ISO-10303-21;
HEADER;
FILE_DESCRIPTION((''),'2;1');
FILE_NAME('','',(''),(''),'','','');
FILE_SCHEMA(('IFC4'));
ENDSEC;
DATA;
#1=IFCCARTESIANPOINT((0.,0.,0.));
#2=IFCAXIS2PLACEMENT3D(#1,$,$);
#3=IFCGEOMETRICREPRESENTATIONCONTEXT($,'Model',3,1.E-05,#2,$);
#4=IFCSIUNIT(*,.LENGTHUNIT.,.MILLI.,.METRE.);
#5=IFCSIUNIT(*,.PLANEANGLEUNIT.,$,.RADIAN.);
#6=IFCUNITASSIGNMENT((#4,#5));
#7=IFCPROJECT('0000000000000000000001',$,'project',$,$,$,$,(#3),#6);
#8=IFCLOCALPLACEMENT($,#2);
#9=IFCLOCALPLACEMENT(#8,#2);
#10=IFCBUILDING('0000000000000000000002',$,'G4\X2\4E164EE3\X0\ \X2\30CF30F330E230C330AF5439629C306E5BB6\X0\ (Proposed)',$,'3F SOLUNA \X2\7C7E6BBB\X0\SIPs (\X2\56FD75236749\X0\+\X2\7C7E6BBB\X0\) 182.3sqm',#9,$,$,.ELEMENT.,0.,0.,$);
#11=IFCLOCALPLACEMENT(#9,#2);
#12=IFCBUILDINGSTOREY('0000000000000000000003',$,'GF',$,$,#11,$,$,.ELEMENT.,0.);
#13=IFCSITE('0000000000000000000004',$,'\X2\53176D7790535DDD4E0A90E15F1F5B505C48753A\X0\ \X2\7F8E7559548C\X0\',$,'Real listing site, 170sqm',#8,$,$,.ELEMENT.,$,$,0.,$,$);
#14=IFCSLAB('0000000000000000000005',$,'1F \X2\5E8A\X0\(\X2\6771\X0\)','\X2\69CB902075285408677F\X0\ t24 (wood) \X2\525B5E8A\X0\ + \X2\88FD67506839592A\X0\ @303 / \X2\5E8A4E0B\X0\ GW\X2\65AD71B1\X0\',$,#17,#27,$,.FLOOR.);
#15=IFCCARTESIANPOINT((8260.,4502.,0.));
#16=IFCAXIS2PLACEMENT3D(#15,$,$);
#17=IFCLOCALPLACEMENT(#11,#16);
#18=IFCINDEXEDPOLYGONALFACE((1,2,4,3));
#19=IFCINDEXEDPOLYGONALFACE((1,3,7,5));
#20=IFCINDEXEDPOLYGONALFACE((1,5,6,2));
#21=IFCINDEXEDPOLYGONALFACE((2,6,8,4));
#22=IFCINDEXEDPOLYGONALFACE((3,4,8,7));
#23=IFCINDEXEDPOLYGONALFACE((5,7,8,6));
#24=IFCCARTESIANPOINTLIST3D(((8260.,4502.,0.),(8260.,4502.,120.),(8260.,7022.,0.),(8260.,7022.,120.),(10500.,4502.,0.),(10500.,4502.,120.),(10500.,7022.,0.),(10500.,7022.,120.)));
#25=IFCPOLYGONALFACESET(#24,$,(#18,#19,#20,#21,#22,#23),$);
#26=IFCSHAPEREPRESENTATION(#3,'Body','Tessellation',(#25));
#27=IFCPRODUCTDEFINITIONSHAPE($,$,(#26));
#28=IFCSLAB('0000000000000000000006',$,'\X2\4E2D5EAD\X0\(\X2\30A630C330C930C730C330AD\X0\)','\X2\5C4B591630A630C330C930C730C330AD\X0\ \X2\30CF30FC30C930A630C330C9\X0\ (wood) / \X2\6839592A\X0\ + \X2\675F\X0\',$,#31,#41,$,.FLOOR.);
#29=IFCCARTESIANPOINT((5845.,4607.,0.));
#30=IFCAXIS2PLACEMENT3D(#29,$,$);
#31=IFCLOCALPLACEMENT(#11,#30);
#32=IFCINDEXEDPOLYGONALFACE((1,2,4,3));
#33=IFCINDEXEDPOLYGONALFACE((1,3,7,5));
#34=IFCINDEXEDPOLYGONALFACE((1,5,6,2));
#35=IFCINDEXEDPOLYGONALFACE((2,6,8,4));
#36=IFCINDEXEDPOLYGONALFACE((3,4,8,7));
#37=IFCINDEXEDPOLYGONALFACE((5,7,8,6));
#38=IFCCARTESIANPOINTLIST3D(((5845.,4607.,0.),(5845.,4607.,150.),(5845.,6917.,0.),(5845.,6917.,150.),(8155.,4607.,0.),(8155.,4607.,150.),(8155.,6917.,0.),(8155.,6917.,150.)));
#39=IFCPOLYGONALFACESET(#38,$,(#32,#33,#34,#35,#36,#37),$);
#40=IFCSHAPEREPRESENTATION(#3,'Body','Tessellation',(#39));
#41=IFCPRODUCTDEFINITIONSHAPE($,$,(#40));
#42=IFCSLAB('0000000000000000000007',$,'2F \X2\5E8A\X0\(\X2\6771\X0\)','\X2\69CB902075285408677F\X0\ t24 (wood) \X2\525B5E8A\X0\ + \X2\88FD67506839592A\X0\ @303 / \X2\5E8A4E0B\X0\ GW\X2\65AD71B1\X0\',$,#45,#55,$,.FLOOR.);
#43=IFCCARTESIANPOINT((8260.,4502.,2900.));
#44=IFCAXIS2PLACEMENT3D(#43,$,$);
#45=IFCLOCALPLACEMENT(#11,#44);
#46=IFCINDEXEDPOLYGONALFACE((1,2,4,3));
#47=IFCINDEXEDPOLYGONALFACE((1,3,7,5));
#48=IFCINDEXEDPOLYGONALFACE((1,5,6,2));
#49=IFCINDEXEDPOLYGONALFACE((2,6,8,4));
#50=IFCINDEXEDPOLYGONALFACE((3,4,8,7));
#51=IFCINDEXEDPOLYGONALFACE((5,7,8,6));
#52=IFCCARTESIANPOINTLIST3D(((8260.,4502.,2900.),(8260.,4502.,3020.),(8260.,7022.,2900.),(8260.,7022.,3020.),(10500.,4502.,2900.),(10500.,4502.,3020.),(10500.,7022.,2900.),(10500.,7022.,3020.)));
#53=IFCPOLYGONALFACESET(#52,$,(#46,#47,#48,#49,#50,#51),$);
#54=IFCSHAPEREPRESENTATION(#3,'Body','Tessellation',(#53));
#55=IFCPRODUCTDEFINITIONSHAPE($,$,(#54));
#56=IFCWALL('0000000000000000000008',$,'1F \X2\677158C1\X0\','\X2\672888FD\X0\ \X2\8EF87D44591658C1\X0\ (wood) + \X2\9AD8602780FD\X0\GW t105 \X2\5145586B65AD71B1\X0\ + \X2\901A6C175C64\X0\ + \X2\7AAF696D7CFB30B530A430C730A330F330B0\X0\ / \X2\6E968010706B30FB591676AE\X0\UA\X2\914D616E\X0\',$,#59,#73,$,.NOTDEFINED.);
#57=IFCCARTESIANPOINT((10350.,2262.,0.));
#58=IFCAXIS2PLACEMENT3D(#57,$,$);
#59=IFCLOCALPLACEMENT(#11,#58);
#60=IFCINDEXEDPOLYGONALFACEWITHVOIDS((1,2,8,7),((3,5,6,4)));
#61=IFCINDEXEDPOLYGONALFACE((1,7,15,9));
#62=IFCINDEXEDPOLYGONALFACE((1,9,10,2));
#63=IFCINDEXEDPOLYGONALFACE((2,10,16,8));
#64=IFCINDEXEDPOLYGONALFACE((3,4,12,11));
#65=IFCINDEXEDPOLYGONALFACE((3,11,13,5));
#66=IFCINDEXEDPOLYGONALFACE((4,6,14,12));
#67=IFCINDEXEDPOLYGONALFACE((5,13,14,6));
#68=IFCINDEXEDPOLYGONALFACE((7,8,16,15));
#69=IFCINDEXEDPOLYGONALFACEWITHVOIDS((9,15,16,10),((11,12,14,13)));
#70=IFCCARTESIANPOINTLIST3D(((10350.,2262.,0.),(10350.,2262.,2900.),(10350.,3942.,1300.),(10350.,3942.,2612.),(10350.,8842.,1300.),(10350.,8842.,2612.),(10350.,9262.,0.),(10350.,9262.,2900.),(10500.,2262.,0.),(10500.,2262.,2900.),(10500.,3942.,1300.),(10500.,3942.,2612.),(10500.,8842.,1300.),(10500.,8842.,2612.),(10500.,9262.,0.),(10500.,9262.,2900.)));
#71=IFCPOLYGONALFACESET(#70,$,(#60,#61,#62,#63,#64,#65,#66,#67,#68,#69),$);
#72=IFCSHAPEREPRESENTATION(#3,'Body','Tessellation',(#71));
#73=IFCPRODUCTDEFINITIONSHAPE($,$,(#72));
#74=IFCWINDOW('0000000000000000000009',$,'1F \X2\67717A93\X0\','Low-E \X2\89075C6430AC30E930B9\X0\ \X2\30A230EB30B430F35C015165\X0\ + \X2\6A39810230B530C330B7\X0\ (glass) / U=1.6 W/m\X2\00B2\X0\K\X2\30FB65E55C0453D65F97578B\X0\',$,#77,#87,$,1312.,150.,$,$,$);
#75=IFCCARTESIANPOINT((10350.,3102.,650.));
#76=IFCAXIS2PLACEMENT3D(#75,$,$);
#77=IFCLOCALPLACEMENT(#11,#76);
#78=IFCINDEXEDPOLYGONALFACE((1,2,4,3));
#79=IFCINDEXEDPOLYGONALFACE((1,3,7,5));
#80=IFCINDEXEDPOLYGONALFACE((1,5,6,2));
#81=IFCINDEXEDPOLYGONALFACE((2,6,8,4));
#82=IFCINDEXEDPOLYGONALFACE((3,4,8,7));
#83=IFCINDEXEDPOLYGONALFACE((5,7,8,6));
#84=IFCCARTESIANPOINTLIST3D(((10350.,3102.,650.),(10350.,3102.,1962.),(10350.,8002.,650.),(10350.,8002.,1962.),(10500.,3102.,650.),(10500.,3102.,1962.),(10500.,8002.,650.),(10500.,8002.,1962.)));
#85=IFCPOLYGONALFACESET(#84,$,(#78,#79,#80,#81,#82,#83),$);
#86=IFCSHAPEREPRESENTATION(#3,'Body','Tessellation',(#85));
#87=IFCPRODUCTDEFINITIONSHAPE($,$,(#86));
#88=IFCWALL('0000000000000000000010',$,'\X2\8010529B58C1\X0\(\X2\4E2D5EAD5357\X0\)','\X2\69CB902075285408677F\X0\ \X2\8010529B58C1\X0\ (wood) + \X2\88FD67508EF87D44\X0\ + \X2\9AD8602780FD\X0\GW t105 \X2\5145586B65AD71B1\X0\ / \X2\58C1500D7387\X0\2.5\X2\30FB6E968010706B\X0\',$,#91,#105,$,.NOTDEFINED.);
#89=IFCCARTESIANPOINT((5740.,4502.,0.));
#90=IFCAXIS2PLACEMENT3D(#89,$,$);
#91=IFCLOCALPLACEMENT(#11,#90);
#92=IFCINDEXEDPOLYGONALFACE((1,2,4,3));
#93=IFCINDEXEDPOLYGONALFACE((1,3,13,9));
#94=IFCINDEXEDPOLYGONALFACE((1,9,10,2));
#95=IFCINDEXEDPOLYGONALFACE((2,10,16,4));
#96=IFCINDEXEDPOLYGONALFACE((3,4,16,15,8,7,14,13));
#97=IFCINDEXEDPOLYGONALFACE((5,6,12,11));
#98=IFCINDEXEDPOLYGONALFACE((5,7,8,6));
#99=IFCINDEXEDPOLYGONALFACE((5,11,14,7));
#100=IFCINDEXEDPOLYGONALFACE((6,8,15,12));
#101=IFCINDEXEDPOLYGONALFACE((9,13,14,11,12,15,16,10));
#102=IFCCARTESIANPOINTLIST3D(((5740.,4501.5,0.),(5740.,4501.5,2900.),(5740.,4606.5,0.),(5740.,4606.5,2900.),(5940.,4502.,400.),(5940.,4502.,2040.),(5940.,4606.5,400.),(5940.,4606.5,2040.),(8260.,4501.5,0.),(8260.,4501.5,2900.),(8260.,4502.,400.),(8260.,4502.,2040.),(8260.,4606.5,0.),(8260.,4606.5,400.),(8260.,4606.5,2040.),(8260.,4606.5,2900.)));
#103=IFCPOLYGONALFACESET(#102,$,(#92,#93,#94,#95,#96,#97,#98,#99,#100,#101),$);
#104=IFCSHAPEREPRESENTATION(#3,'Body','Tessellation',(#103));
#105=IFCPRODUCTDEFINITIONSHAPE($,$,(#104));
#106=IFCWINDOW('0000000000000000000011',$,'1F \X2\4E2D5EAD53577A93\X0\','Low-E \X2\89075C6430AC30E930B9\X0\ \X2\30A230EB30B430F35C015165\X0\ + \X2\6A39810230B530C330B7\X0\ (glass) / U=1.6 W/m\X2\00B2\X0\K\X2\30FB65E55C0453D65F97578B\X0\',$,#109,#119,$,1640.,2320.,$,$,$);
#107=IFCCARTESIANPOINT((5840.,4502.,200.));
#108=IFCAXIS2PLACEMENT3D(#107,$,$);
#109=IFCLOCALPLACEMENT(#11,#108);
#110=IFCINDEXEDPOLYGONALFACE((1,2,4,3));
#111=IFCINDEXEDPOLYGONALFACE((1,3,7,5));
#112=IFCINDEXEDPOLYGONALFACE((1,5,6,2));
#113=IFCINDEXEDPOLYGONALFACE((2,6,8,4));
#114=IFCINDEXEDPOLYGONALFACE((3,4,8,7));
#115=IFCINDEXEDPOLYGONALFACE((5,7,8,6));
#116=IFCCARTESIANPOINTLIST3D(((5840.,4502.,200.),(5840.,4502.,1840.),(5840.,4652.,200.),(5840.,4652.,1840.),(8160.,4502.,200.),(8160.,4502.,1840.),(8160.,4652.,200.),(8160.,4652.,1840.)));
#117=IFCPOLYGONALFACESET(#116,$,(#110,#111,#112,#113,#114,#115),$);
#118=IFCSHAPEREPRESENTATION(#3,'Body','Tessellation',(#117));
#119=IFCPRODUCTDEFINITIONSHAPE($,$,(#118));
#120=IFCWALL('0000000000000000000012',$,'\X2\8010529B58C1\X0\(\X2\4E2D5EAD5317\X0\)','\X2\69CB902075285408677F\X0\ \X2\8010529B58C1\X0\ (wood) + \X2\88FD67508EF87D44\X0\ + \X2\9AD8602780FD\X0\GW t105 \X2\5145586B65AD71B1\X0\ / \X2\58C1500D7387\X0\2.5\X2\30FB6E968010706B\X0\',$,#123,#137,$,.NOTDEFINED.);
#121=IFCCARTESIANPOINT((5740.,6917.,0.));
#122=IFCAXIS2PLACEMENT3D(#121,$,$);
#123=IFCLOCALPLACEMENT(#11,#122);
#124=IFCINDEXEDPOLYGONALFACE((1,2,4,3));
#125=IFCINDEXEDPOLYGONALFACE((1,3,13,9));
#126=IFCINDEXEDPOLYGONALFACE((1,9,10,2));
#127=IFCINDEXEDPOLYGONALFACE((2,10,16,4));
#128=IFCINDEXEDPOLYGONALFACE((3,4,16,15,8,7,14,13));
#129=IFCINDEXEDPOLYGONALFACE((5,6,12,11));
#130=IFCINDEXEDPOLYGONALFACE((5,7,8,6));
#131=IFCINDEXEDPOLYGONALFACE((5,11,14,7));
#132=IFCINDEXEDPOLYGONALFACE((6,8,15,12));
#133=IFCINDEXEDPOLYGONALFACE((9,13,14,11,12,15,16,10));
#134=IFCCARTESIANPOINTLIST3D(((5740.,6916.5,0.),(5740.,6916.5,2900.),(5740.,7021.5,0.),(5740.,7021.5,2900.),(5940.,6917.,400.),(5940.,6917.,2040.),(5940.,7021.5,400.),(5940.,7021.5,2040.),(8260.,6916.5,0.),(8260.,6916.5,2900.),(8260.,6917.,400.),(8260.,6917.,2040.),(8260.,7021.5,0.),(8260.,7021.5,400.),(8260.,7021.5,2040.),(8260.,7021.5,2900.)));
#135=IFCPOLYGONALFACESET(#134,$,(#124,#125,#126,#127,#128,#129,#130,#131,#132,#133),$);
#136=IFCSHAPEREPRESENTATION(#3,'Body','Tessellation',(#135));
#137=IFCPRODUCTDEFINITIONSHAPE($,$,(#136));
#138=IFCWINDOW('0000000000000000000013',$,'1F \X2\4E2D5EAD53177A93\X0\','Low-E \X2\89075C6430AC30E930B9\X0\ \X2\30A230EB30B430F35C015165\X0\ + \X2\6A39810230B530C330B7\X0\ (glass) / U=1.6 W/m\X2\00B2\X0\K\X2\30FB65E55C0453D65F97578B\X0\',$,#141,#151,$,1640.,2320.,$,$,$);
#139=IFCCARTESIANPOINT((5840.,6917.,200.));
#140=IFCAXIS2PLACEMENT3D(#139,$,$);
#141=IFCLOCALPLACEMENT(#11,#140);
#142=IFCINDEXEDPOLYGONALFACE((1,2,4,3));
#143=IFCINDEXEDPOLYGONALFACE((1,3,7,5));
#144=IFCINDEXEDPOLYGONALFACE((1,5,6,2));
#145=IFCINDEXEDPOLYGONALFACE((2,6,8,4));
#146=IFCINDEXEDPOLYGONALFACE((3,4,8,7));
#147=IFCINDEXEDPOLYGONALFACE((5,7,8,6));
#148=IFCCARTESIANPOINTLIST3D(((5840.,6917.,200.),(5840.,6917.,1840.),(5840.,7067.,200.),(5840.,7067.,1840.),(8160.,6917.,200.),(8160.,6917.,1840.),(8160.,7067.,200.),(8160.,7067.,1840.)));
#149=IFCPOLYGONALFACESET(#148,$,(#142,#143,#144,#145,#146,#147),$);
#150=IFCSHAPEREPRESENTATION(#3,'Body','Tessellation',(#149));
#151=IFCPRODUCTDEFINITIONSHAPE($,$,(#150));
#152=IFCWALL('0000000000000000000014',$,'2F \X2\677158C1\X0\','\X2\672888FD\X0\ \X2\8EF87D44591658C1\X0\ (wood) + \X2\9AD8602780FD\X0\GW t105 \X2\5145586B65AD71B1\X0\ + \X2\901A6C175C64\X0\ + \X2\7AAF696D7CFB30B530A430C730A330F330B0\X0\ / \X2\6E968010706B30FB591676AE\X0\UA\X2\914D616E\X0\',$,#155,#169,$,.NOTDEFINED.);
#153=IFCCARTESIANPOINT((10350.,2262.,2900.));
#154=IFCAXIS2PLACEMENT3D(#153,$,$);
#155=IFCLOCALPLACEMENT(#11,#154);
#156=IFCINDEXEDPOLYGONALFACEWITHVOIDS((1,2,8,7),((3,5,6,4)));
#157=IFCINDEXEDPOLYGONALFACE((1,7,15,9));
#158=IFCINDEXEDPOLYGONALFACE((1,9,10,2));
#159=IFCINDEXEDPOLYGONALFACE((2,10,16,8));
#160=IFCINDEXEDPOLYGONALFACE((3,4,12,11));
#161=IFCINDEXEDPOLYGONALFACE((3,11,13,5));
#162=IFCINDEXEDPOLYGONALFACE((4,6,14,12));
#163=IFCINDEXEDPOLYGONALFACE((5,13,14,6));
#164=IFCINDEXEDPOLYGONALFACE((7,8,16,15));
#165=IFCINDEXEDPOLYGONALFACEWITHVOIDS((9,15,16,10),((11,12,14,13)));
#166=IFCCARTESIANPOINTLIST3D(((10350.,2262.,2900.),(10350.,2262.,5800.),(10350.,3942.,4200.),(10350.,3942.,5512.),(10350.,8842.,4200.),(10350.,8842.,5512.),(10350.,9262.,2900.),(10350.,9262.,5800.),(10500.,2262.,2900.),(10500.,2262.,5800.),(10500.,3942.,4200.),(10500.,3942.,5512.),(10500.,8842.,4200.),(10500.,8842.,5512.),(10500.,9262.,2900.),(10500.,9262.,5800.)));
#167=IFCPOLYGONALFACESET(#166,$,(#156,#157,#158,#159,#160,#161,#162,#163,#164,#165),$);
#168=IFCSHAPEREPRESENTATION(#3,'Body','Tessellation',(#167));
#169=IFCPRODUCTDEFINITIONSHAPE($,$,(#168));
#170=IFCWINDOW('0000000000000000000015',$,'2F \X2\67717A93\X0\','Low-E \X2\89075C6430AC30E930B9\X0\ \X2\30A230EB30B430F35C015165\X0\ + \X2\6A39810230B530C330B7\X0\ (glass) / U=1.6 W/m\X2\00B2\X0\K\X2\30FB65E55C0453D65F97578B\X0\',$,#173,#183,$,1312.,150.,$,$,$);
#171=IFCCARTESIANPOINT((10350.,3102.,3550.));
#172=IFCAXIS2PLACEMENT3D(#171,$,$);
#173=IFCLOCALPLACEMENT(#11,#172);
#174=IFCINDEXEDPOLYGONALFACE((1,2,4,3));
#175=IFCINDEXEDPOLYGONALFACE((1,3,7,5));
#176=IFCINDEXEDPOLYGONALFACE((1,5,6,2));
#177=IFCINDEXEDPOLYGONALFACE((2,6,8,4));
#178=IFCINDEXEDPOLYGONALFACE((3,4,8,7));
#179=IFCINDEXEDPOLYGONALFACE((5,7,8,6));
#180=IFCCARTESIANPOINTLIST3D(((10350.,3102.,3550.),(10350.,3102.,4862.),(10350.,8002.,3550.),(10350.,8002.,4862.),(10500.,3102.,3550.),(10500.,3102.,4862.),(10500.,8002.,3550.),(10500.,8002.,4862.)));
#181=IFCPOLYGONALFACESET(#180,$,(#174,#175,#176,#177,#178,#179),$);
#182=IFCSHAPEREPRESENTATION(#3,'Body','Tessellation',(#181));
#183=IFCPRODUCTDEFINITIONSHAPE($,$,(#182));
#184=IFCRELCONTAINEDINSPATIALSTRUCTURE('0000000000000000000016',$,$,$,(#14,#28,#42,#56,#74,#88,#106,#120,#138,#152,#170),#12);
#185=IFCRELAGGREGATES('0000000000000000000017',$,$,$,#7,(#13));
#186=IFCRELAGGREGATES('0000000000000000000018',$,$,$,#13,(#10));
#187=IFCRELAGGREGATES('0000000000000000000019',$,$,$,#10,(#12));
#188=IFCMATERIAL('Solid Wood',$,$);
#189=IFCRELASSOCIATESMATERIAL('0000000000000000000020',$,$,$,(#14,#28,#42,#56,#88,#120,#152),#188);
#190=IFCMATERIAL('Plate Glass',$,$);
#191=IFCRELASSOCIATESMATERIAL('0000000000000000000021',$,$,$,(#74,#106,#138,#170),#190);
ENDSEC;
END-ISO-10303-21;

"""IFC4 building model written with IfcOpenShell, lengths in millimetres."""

from ifc_helpers import new_model, si_unit, frame, frame_2d, origin, place, context, project, spatial, rectangle, extrude, material, element, fill, save


model = new_model("IFC4")

# Units and contexts
model_context = context("Model", 3, precision=1e-05, world=origin())
ifc_project = project(units=[si_unit("LENGTHUNIT", "METRE", prefix="MILLI"), si_unit("PLANEANGLEUNIT", "RADIAN")], contexts=[model_context])

# Site, building, storey
site_placement = place(None, origin())
site = spatial("IfcSite", under=ifc_project, at=site_placement, Name="北海道川上郡弟子屈町 美留和", ObjectType="Real listing site, 170sqm", CompositionType="ELEMENT", RefElevation=0.0)
building_placement = place(site_placement, origin())
building = spatial("IfcBuilding", under=site, at=building_placement, Name="G4世代 ハンモック吹抜の家 (Proposed)", ObjectType="3F SOLUNA 籾殻SIPs (国産杉+籾殻) 182.3sqm", CompositionType="ELEMENT", ElevationOfRefHeight=0.0, ElevationOfTerrain=0.0)
storey_placement = place(building_placement, origin())
storey = spatial("IfcBuildingStorey", under=building, at=storey_placement, Name="GF", CompositionType="ELEMENT", Elevation=0.0)

# Slabs
ifc_material_1 = material(Name="Solid Wood")
slab_1_placement = place(storey_placement, frame((8260.0, 4502.0, 0.0)))
element("IfcSlab", 1, at=slab_1_placement, inside=storey, material=ifc_material_1, Name="1F 床(東)", Description="構造用合板 t24 (wood) 剛床 + 製材根太 @303 / 床下 GW断熱", PredefinedType="FLOOR", context=model_context, shape_type="SweptSolid", body=[
    extrude(rectangle(XDim=2240.0, YDim=2520.0, at=frame_2d((1120.0, 1260.0))), frame((8260.0, 4502.0, 0.0)), (0.0, 0.0, 1.0), 120.0),
])
slab_2_placement = place(storey_placement, frame((5845.0, 4607.0, 0.0)))
element("IfcSlab", 2, at=slab_2_placement, inside=storey, material=ifc_material_1, Name="中庭(ウッドデッキ)", Description="屋外ウッドデッキ ハードウッド (wood) / 根太 + 束", PredefinedType="FLOOR", context=model_context, shape_type="SweptSolid", body=[
    extrude(rectangle(XDim=2310.0, YDim=2310.0, at=frame_2d((1155.0, 1155.0))), frame((5845.0, 4607.0, 0.0)), (0.0, 0.0, 1.0), 150.0),
])
slab_3_placement = place(storey_placement, frame((8260.0, 4502.0, 2900.0)))
element("IfcSlab", 3, at=slab_3_placement, inside=storey, material=ifc_material_1, Name="2F 床(東)", Description="構造用合板 t24 (wood) 剛床 + 製材根太 @303 / 床下 GW断熱", PredefinedType="FLOOR", context=model_context, shape_type="SweptSolid", body=[
    extrude(rectangle(XDim=2240.0, YDim=2520.0, at=frame_2d((1120.0, 1260.0))), frame((8260.0, 4502.0, 2900.0)), (0.0, 0.0, 1.0), 120.0),
])

# Walls, openings, windows
wall_1_placement = place(storey_placement, frame((10350.0, 2262.0, 0.0)))
wall_1 = element("IfcWall", 4, at=wall_1_placement, inside=storey, material=ifc_material_1, Name="1F 東壁", Description="木製 軸組外壁 (wood) + 高性能GW t105 充填断熱 + 通気層 + 窯業系サイディング / 準耐火・外皮UA配慮", PredefinedType="NOTDEFINED", context=model_context, shape_type="SweptSolid", body=[
    extrude(rectangle(XDim=150.0, YDim=7000.0, at=frame_2d((75.0, 3500.0))), frame((10350.0, 2262.0, 0.0)), (0.0, 0.0, 1.0), 2900.0),
])
opening_1_placement = place(storey_placement, frame((10350.0, 3102.0, 650.0)))
opening_1 = element("IfcOpeningElement", 5, at=opening_1_placement, cuts=wall_1, PredefinedType="NOTDEFINED", context=model_context, shape_type="SweptSolid", body=[
    extrude(rectangle(XDim=150.0, YDim=4900.0, at=frame_2d((75.0, 2450.0))), frame((10350.0, 3102.0, 650.0)), (0.0, 0.0, 1.0), 1312.0),
])
ifc_material_2 = material(Name="Plate Glass")
window_1_placement = place(storey_placement, frame((10350.0, 3102.0, 650.0)))
window_1 = element("IfcWindow", 6, at=window_1_placement, inside=storey, material=ifc_material_2, Name="1F 東窓", Description="Low-E 複層ガラス アルゴン封入 + 樹脂サッシ (glass) / U=1.6 W/m²K・日射取得型", OverallHeight=1312.0, OverallWidth=150.0, context=model_context, shape_type="SweptSolid", body=[
    extrude(rectangle(XDim=150.0, YDim=4900.0, at=frame_2d((75.0, 2450.0))), frame((10350.0, 3102.0, 650.0)), (0.0, 0.0, 1.0), 1312.0),
])
fill(opening_1, window_1)
wall_2_placement = place(storey_placement, frame((5740.0, 4502.0, 0.0)))
wall_2 = element("IfcWall", 7, at=wall_2_placement, inside=storey, material=ifc_material_1, Name="耐力壁(中庭南)", Description="構造用合板 耐力壁 (wood) + 製材軸組 + 高性能GW t105 充填断熱 / 壁倍率2.5・準耐火", PredefinedType="NOTDEFINED", context=model_context, shape_type="SweptSolid", body=[
    extrude(rectangle(XDim=2520.0, YDim=105.0, at=frame_2d((1260.0, 52.0))), frame((5740.0, 4502.0, 0.0)), (0.0, 0.0, 1.0), 2900.0),
])
opening_2_placement = place(storey_placement, frame((5840.0, 4502.0, 200.0)))
opening_2 = element("IfcOpeningElement", 8, at=opening_2_placement, cuts=wall_2, PredefinedType="NOTDEFINED", context=model_context, shape_type="SweptSolid", body=[
    extrude(rectangle(XDim=2320.0, YDim=150.0, at=frame_2d((1160.0, 75.0))), frame((5840.0, 4502.0, 200.0)), (0.0, 0.0, 1.0), 1640.0),
])
window_2_placement = place(storey_placement, frame((5840.0, 4502.0, 200.0)))
window_2 = element("IfcWindow", 9, at=window_2_placement, inside=storey, material=ifc_material_2, Name="1F 中庭南窓", Description="Low-E 複層ガラス アルゴン封入 + 樹脂サッシ (glass) / U=1.6 W/m²K・日射取得型", OverallHeight=1640.0, OverallWidth=2320.0, context=model_context, shape_type="SweptSolid", body=[
    extrude(rectangle(XDim=2320.0, YDim=150.0, at=frame_2d((1160.0, 75.0))), frame((5840.0, 4502.0, 200.0)), (0.0, 0.0, 1.0), 1640.0),
])
fill(opening_2, window_2)
wall_3_placement = place(storey_placement, frame((5740.0, 6917.0, 0.0)))
wall_3 = element("IfcWall", 10, at=wall_3_placement, inside=storey, material=ifc_material_1, Name="耐力壁(中庭北)", Description="構造用合板 耐力壁 (wood) + 製材軸組 + 高性能GW t105 充填断熱 / 壁倍率2.5・準耐火", PredefinedType="NOTDEFINED", context=model_context, shape_type="SweptSolid", body=[
    extrude(rectangle(XDim=2520.0, YDim=105.0, at=frame_2d((1260.0, 52.0))), frame((5740.0, 6917.0, 0.0)), (0.0, 0.0, 1.0), 2900.0),
])
opening_3_placement = place(storey_placement, frame((5840.0, 6917.0, 200.0)))
opening_3 = element("IfcOpeningElement", 11, at=opening_3_placement, cuts=wall_3, PredefinedType="NOTDEFINED", context=model_context, shape_type="SweptSolid", body=[
    extrude(rectangle(XDim=2320.0, YDim=150.0, at=frame_2d((1160.0, 75.0))), frame((5840.0, 6917.0, 200.0)), (0.0, 0.0, 1.0), 1640.0),
])
window_3_placement = place(storey_placement, frame((5840.0, 6917.0, 200.0)))
window_3 = element("IfcWindow", 12, at=window_3_placement, inside=storey, material=ifc_material_2, Name="1F 中庭北窓", Description="Low-E 複層ガラス アルゴン封入 + 樹脂サッシ (glass) / U=1.6 W/m²K・日射取得型", OverallHeight=1640.0, OverallWidth=2320.0, context=model_context, shape_type="SweptSolid", body=[
    extrude(rectangle(XDim=2320.0, YDim=150.0, at=frame_2d((1160.0, 75.0))), frame((5840.0, 6917.0, 200.0)), (0.0, 0.0, 1.0), 1640.0),
])
fill(opening_3, window_3)

# Wall, opening, window
wall_4_placement = place(storey_placement, frame((10350.0, 2262.0, 2900.0)))
wall_4 = element("IfcWall", 13, at=wall_4_placement, inside=storey, material=ifc_material_1, Name="2F 東壁", Description="木製 軸組外壁 (wood) + 高性能GW t105 充填断熱 + 通気層 + 窯業系サイディング / 準耐火・外皮UA配慮", PredefinedType="NOTDEFINED", context=model_context, shape_type="SweptSolid", body=[
    extrude(rectangle(XDim=150.0, YDim=7000.0, at=frame_2d((75.0, 3500.0))), frame((10350.0, 2262.0, 2900.0)), (0.0, 0.0, 1.0), 2900.0),
])
opening_4_placement = place(storey_placement, frame((10350.0, 3102.0, 3550.0)))
opening_4 = element("IfcOpeningElement", 14, at=opening_4_placement, cuts=wall_4, PredefinedType="NOTDEFINED", context=model_context, shape_type="SweptSolid", body=[
    extrude(rectangle(XDim=150.0, YDim=4900.0, at=frame_2d((75.0, 2450.0))), frame((10350.0, 3102.0, 3550.0)), (0.0, 0.0, 1.0), 1312.0),
])
window_4_placement = place(storey_placement, frame((10350.0, 3102.0, 3550.0)))
window_4 = element("IfcWindow", 15, at=window_4_placement, inside=storey, material=ifc_material_2, Name="2F 東窓", Description="Low-E 複層ガラス アルゴン封入 + 樹脂サッシ (glass) / U=1.6 W/m²K・日射取得型", OverallHeight=1312.0, OverallWidth=150.0, context=model_context, shape_type="SweptSolid", body=[
    extrude(rectangle(XDim=150.0, YDim=4900.0, at=frame_2d((75.0, 2450.0))), frame((10350.0, 3102.0, 3550.0)), (0.0, 0.0, 1.0), 1312.0),
])
fill(opening_4, window_4)

save(model, "model.ifc")
